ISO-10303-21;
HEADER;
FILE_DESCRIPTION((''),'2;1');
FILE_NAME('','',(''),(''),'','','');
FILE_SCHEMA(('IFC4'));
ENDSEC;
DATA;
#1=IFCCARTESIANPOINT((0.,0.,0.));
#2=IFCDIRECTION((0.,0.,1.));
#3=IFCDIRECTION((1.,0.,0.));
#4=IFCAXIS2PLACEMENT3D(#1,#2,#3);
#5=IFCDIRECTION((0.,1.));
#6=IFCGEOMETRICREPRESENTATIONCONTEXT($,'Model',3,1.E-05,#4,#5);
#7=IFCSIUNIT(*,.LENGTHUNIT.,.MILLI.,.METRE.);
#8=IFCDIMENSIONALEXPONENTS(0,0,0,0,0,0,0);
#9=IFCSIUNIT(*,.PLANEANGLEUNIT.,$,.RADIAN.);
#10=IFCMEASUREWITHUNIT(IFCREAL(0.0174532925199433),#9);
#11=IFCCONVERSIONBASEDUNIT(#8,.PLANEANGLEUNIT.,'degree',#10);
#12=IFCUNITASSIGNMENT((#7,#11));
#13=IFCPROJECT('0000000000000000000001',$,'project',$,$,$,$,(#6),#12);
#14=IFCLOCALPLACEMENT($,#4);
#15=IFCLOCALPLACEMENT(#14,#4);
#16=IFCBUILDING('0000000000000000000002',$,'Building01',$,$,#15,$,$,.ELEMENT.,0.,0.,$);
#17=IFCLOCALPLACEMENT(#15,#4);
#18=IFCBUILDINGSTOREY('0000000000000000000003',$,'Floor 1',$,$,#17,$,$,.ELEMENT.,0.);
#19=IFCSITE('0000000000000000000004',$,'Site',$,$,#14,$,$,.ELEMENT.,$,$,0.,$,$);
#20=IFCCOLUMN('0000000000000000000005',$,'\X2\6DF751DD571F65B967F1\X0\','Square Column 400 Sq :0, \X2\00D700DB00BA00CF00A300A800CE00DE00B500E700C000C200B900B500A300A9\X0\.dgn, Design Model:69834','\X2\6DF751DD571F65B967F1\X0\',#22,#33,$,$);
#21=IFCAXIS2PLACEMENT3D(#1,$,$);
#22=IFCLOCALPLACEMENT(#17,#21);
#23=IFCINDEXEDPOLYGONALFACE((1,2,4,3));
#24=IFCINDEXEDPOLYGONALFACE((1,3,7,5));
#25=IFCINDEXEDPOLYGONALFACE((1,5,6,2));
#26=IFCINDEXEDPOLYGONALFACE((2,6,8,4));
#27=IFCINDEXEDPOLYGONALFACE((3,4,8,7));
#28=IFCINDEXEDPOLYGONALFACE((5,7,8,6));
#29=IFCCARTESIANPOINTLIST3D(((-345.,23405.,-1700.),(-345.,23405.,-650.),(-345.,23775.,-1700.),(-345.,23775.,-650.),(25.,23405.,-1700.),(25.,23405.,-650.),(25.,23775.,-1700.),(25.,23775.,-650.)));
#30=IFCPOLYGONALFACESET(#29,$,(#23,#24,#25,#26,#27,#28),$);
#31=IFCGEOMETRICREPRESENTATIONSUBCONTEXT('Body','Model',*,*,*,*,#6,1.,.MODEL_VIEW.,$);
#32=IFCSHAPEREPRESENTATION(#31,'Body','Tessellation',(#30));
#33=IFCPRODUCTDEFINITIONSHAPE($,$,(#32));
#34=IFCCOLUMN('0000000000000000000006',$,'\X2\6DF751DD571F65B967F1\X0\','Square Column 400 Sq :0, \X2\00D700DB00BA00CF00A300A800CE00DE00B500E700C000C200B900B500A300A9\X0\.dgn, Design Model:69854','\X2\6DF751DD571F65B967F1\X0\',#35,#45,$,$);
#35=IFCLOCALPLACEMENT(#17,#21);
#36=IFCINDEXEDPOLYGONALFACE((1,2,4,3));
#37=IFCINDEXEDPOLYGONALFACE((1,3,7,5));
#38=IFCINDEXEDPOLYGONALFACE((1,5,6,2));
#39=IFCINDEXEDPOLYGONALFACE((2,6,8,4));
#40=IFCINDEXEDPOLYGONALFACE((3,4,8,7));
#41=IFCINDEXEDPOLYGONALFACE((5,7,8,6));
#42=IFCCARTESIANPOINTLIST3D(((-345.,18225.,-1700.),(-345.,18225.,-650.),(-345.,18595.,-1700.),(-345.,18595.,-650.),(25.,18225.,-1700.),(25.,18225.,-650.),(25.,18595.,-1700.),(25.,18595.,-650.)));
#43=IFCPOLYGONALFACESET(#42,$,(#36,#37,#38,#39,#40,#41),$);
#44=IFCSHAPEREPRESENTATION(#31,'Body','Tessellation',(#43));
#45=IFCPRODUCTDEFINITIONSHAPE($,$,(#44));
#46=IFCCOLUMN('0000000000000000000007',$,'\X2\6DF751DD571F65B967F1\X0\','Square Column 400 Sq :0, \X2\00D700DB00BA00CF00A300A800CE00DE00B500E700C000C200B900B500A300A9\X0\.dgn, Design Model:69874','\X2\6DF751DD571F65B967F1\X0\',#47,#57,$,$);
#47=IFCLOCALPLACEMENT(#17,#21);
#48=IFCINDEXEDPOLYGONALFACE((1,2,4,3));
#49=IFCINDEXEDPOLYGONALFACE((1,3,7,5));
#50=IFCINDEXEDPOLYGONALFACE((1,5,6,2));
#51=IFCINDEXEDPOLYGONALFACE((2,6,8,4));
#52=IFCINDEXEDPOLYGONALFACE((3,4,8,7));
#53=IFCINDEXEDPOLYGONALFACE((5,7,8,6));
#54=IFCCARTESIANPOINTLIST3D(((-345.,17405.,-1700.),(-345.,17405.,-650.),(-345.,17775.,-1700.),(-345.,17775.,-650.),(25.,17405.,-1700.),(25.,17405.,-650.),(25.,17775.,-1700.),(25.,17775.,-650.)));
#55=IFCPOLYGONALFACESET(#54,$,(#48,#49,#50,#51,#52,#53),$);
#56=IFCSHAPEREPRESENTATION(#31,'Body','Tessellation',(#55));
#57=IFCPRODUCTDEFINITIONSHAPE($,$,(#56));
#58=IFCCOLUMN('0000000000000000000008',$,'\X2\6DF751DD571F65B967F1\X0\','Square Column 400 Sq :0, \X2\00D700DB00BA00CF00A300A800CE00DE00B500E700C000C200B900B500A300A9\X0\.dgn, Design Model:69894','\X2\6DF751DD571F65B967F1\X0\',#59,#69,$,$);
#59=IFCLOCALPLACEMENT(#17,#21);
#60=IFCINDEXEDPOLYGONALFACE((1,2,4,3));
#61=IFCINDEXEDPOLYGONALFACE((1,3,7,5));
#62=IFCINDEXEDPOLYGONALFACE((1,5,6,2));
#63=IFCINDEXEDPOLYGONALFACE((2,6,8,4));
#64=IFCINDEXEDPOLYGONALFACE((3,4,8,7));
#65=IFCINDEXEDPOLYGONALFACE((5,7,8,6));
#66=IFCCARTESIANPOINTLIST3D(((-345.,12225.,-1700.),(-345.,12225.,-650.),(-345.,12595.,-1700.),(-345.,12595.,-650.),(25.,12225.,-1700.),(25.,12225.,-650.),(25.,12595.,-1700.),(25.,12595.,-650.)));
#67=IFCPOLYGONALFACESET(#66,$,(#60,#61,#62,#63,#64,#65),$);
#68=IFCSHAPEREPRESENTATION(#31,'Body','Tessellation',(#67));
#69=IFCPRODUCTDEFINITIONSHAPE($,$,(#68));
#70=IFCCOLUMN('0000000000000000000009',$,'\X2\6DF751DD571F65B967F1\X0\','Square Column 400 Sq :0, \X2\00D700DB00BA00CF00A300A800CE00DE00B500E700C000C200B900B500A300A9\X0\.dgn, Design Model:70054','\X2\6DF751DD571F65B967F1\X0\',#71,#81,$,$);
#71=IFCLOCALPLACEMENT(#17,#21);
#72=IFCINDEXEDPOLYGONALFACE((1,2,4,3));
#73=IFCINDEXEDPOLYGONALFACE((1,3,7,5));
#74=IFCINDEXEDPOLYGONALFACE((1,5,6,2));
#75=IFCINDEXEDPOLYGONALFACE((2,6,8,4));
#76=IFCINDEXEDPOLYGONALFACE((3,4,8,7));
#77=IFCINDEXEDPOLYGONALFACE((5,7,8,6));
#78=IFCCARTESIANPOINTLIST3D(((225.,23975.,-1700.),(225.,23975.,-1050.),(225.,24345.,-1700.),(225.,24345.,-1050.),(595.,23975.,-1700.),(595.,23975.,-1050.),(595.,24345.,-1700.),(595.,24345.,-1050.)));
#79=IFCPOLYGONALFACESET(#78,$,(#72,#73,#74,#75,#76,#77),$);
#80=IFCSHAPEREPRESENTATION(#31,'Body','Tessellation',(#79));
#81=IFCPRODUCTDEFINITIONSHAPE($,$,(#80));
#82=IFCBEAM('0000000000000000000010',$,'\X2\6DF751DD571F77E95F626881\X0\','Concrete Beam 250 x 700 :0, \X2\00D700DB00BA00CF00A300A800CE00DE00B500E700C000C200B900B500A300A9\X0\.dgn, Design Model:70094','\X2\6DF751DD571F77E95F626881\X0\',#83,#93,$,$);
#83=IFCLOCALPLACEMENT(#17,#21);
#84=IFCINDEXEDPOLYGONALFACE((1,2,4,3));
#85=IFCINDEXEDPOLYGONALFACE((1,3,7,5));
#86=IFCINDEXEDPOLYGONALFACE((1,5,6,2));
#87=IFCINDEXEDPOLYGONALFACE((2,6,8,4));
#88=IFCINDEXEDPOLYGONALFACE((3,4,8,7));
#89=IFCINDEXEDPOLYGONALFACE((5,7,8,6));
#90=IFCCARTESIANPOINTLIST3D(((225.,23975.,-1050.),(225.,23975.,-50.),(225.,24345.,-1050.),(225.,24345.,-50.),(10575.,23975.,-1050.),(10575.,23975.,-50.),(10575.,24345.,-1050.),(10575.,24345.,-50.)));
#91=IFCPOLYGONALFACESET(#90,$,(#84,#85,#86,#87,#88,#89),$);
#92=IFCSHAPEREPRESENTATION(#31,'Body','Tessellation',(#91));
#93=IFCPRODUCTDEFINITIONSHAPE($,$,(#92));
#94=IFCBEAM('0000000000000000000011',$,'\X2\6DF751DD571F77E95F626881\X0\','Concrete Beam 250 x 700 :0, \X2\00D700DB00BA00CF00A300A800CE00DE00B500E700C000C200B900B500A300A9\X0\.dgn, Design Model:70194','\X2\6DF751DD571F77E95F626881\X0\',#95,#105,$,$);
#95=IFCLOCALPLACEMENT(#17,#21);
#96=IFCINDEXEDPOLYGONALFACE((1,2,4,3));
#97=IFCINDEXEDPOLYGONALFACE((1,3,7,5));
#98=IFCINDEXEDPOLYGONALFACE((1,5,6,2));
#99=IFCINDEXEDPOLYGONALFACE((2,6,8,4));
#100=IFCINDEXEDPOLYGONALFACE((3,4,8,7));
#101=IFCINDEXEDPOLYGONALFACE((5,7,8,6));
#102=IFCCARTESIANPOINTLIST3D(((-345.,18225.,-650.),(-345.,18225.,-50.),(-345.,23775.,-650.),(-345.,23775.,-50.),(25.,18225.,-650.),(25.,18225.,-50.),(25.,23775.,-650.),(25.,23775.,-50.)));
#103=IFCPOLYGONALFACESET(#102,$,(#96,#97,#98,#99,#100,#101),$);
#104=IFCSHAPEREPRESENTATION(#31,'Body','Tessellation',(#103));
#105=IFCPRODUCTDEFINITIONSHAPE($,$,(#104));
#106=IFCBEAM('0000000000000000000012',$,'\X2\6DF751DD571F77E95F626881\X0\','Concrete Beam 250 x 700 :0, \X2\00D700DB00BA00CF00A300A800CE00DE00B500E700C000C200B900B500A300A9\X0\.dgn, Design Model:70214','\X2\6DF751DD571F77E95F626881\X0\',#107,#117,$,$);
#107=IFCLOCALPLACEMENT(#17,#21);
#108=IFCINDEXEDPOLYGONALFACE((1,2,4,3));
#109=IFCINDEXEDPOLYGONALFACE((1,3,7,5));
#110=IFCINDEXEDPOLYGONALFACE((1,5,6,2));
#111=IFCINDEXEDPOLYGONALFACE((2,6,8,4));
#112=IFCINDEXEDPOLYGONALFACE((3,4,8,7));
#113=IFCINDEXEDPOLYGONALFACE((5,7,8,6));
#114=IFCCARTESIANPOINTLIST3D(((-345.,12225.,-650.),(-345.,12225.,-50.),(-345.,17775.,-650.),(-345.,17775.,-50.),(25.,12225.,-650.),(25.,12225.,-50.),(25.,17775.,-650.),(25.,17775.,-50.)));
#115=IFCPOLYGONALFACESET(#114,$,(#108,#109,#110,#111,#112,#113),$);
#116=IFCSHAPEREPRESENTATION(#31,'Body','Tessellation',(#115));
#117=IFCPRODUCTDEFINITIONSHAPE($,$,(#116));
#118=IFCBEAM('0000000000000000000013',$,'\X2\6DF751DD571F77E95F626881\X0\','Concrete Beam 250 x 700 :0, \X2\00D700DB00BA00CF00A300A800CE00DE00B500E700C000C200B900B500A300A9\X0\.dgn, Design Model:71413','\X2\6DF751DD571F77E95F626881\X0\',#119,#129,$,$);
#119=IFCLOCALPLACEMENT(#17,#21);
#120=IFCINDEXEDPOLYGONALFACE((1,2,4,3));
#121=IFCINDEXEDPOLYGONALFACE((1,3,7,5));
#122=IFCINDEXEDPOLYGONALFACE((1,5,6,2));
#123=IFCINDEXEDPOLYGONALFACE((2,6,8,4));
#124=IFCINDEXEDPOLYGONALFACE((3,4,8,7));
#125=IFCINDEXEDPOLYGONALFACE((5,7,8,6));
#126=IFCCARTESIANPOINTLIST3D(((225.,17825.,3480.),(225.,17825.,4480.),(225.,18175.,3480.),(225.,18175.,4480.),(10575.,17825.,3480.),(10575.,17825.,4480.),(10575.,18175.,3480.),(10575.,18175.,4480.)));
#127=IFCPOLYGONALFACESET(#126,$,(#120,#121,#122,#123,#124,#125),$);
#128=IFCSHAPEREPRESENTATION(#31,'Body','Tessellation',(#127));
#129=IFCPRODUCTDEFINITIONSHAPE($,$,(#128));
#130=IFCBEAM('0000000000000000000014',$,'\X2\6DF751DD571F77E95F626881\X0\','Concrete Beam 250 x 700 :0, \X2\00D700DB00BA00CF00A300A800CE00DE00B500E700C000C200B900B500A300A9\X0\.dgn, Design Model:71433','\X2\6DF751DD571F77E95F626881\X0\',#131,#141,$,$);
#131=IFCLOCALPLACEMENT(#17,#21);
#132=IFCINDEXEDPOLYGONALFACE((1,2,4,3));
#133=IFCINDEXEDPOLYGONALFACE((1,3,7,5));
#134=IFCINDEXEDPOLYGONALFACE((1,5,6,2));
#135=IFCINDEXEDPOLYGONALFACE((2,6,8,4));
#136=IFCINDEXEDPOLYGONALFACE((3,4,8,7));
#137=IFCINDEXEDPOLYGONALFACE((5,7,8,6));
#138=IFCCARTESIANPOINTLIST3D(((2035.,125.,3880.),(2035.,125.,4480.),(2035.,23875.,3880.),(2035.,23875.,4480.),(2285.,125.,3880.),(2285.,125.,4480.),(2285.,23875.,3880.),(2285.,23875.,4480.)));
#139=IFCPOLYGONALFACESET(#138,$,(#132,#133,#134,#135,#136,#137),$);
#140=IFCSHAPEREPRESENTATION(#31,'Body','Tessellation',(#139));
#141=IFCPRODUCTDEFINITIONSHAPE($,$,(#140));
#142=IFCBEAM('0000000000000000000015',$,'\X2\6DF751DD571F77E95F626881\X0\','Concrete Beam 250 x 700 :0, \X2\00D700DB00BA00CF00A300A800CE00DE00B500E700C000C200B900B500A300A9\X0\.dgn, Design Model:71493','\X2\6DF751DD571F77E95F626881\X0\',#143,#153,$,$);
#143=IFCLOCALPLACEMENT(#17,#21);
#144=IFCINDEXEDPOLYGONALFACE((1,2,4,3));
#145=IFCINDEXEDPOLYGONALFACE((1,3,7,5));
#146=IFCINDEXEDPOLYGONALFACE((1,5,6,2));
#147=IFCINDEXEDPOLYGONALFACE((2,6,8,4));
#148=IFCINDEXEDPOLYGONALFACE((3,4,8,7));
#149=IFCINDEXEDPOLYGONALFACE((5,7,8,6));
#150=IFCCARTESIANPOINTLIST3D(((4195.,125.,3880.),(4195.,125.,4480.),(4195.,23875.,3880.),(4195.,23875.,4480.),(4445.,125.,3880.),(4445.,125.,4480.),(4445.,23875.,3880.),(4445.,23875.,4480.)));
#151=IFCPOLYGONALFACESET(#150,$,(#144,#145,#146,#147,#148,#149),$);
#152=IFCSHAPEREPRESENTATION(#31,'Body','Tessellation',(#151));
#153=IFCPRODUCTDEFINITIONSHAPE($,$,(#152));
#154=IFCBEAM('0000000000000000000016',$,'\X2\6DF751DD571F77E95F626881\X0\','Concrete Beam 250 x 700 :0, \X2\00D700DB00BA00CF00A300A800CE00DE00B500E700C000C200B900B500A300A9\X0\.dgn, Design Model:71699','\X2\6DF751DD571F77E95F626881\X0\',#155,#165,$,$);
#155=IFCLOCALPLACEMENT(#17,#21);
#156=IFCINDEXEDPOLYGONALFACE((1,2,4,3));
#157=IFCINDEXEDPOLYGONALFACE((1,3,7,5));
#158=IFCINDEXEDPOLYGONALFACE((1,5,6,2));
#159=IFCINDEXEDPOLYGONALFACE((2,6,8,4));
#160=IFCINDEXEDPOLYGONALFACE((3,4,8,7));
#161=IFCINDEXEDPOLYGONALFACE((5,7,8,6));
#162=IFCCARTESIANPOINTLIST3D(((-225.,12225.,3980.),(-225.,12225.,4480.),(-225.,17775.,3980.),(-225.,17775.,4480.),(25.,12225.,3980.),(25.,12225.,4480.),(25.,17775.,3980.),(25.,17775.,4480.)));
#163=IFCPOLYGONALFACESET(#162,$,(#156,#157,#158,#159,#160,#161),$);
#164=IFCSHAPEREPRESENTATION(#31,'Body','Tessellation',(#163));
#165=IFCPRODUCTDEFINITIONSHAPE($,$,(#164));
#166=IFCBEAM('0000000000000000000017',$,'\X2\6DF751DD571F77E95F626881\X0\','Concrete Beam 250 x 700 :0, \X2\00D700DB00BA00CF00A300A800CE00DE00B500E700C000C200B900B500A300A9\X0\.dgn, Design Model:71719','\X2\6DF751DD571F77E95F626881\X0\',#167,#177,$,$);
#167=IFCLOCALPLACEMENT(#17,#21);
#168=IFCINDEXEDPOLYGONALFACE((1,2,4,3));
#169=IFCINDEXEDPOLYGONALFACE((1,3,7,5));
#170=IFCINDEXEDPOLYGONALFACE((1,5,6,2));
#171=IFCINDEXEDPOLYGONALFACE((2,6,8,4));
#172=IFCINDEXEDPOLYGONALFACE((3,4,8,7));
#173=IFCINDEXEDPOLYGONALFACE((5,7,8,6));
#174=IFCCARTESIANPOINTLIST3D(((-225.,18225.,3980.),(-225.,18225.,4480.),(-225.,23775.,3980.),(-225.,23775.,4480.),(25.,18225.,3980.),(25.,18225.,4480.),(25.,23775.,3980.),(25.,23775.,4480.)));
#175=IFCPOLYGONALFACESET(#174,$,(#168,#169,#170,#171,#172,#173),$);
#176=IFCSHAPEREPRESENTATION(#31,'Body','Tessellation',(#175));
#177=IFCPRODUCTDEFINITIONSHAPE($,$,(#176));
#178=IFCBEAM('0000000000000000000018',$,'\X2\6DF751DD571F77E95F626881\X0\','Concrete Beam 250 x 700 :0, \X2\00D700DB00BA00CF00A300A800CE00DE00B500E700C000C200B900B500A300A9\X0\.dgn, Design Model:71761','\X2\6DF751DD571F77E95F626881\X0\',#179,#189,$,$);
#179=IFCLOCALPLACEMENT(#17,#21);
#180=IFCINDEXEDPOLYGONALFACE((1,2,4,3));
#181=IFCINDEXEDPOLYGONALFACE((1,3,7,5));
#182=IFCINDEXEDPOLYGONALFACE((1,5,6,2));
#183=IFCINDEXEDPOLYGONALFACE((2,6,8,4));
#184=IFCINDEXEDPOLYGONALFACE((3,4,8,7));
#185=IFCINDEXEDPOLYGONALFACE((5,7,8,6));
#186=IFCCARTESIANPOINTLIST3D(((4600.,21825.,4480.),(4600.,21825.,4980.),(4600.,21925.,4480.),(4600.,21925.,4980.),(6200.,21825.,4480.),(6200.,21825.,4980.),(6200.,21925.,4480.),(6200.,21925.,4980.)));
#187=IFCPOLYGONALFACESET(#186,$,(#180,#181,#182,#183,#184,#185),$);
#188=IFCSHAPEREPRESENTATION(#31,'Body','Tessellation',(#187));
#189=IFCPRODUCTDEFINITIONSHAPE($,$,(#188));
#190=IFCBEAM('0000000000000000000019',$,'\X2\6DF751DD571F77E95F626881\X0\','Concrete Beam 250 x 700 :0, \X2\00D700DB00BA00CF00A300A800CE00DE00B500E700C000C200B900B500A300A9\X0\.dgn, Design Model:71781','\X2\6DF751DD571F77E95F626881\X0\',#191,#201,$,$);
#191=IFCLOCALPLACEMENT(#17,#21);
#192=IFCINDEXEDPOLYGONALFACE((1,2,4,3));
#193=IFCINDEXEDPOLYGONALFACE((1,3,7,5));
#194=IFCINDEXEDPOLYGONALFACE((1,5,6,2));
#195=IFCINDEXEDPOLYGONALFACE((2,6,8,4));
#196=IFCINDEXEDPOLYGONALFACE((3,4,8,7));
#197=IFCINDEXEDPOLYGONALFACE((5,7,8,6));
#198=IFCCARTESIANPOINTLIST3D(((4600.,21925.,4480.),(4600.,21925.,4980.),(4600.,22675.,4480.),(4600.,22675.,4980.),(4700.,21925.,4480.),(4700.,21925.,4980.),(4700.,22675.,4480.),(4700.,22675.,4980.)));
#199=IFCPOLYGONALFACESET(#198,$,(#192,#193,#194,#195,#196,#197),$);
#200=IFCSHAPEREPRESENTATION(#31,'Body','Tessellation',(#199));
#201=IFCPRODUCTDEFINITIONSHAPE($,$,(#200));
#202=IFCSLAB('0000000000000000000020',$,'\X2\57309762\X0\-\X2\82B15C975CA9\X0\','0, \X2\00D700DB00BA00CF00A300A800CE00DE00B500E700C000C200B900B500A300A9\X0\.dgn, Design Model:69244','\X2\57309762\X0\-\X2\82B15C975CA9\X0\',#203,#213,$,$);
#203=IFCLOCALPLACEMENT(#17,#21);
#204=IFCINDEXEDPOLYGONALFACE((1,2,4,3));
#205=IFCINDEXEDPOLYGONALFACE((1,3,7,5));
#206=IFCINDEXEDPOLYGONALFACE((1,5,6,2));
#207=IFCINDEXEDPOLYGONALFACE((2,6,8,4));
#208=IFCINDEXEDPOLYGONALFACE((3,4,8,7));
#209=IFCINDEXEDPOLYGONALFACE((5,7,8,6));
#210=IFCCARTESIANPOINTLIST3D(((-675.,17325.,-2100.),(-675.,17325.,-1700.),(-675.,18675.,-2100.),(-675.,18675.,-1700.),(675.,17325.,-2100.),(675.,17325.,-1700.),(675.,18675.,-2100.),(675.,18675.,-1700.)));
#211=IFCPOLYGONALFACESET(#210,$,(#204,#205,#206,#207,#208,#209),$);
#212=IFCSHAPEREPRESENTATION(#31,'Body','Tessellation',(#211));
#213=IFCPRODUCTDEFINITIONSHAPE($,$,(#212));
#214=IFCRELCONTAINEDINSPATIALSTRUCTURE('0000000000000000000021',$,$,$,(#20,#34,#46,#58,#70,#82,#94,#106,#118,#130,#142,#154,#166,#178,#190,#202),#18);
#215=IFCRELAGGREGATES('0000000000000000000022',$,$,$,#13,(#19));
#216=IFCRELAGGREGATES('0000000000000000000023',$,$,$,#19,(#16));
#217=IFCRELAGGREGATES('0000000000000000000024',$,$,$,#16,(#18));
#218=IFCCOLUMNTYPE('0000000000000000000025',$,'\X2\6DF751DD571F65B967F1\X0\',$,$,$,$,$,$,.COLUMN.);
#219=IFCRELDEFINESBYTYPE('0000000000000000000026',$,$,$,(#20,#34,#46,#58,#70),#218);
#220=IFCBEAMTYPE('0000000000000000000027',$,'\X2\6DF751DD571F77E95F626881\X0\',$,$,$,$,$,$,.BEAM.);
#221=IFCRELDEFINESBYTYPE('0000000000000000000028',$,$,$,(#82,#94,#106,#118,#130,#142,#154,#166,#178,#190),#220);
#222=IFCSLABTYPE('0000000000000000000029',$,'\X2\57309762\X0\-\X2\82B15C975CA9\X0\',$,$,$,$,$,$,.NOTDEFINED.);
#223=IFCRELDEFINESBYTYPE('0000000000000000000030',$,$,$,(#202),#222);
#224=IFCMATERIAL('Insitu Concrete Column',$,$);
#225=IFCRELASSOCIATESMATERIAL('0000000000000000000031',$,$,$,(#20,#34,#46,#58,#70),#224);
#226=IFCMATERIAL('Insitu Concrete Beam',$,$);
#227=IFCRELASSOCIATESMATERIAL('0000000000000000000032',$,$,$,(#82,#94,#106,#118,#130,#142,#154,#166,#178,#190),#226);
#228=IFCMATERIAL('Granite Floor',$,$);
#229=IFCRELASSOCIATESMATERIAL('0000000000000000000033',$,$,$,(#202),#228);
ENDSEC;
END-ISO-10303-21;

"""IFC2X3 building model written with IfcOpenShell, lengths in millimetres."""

from ifc_helpers import new_model, entity, si_unit, converted_unit, direction, frame, frame_2d, origin_with_axes, place, context, subcontext, project, spatial, rectangle, extrude, material, type_object, element, save


model = new_model("IFC2X3")

# Units and contexts
model_context = context("Model", 3, precision=1e-05, world=origin_with_axes(), true_north=direction((0.0, 1.0)))
body_context = subcontext(model_context, "Body", "Model", "MODEL_VIEW", scale=1.0)
ifc_project = project(units=[si_unit("LENGTHUNIT", "METRE", prefix="MILLI"), converted_unit("PLANEANGLEUNIT", "degree", entity("IfcReal", 0.0174532925199433), si_unit("PLANEANGLEUNIT", "RADIAN"), dimensions=[0, 0, 0, 0, 0, 0, 0])], contexts=[model_context])

# Site, building, storey
site_placement = place(None, origin_with_axes())
site = spatial("IfcSite", under=ifc_project, at=site_placement, Name="Site", CompositionType="ELEMENT", RefElevation=0.0)
building_placement = place(site_placement, origin_with_axes())
building = spatial("IfcBuilding", under=site, at=building_placement, Name="Building01", CompositionType="ELEMENT", ElevationOfRefHeight=0.0, ElevationOfTerrain=0.0)
storey_placement = place(building_placement, origin_with_axes())
storey = spatial("IfcBuildingStorey", under=building, at=storey_placement, Name="Floor 1", CompositionType="ELEMENT", Elevation=0.0)

# Columns
ifc_material_1 = material(Name="Insitu Concrete Column")
column_type = type_object("IfcColumnType", Name="混凝土方柱", PredefinedType="COLUMN")
for number, where, z_axis, x_axis, name, description in (
    (1, (25.0, 23405.0, -1700.0), (0.0, 0.0, 1.0), (0.0, 1.0, 0.0), "混凝土方柱", "Square Column 400 Sq :0, ×ÛºÏ£¨ÎÞµçÀÂ¹µ£©.dgn, Design Model:69834"),
    (2, (25.0, 18595.0, -1700.0), (0.0, 0.0, 1.0), (-1.0, 0.0, 0.0), "混凝土方柱", "Square Column 400 Sq :0, ×ÛºÏ£¨ÎÞµçÀÂ¹µ£©.dgn, Design Model:69854"),
    (3, (25.0, 17405.0, -1700.0), (0.0, 0.0, 1.0), (0.0, 1.0, 0.0), "混凝土方柱", "Square Column 400 Sq :0, ×ÛºÏ£¨ÎÞµçÀÂ¹µ£©.dgn, Design Model:69874"),
    (4, (25.0, 12595.0, -1700.0), (0.0, 0.0, 1.0), (-1.0, 0.0, 0.0), "混凝土方柱", "Square Column 400 Sq :0, ×ÛºÏ£¨ÎÞµçÀÂ¹µ£©.dgn, Design Model:69894"),
):
    element("IfcColumn", number, at=place(storey_placement, frame(where, z_axis=z_axis, x_axis=x_axis)), inside=storey, type_object=column_type, material=ifc_material_1, Name=name, Description=description, ObjectType="混凝土方柱", context=body_context, shape_type="SweptSolid", body=[
        extrude(rectangle(XDim=370.0, YDim=370.0, at=frame_2d((185.0, 185.0), x_axis=(0.0, 1.0))), origin_with_axes(), (0.0, 0.0, 1.0), 1050.0),
    ])
column_placement = place(storey_placement, frame((225.0, 23975.0, -1700.0), z_axis=(0.0, 0.0, 1.0), x_axis=(1.0, 0.0, 0.0)))
element("IfcColumn", 5, at=column_placement, inside=storey, type_object=column_type, material=ifc_material_1, Name="混凝土方柱", Description="Square Column 400 Sq :0, ×ÛºÏ£¨ÎÞµçÀÂ¹µ£©.dgn, Design Model:70054", ObjectType="混凝土方柱", context=body_context, shape_type="SweptSolid", body=[
    extrude(rectangle(XDim=370.0, YDim=370.0, at=frame_2d((185.0, 185.0), x_axis=(0.0, 1.0))), origin_with_axes(), (0.0, 0.0, 1.0), 650.0),
])

# Beams
ifc_material_2 = material(Name="Insitu Concrete Beam")
beam_type = type_object("IfcBeamType", Name="混凝土矩形梁", PredefinedType="BEAM")
beam_1_placement = place(storey_placement, frame((225.0, 24345.0, -1050.0), z_axis=(1.0, 0.0, 0.0), x_axis=(0.0, 0.0, 1.0)))
element("IfcBeam", 6, at=beam_1_placement, inside=storey, type_object=beam_type, material=ifc_material_2, Name="混凝土矩形梁", Description="Concrete Beam 250 x 700 :0, ×ÛºÏ£¨ÎÞµçÀÂ¹µ£©.dgn, Design Model:70094", ObjectType="混凝土矩形梁", context=body_context, shape_type="SweptSolid", body=[
    extrude(rectangle(XDim=370.0, YDim=1000.0, at=frame_2d((500.0, 185.0), x_axis=(0.0, 1.0))), origin_with_axes(), (0.0, 0.0, 1.0), 10350.0),
])
for number, where, z_axis, x_axis, name, description in (
    (7, (-345.0, 18225.0, -650.0), (0.0, 1.0, 0.0), (0.0, 0.0, 1.0), "混凝土矩形梁", "Concrete Beam 250 x 700 :0, ×ÛºÏ£¨ÎÞµçÀÂ¹µ£©.dgn, Design Model:70194"),
    (8, (-345.0, 12225.0, -650.0), (0.0, 1.0, 0.0), (0.0, 0.0, 1.0), "混凝土矩形梁", "Concrete Beam 250 x 700 :0, ×ÛºÏ£¨ÎÞµçÀÂ¹µ£©.dgn, Design Model:70214"),
):
    element("IfcBeam", number, at=place(storey_placement, frame(where, z_axis=z_axis, x_axis=x_axis)), inside=storey, type_object=beam_type, material=ifc_material_2, Name=name, Description=description, ObjectType="混凝土矩形梁", context=body_context, shape_type="SweptSolid", body=[
        extrude(rectangle(XDim=370.0, YDim=600.0, at=frame_2d((300.0, 185.0), x_axis=(0.0, 1.0))), origin_with_axes(), (0.0, 0.0, 1.0), 5550.0),
    ])
beam_2_placement = place(storey_placement, frame((225.0, 17825.0, 3480.0), z_axis=(1.0, 0.0, 0.0), x_axis=(0.0, 1.0, 0.0)))
element("IfcBeam", 9, at=beam_2_placement, inside=storey, type_object=beam_type, material=ifc_material_2, Name="混凝土矩形梁", Description="Concrete Beam 250 x 700 :0, ×ÛºÏ£¨ÎÞµçÀÂ¹µ£©.dgn, Design Model:71413", ObjectType="混凝土矩形梁", context=body_context, shape_type="SweptSolid", body=[
    extrude(rectangle(XDim=1000.0, YDim=350.0, at=frame_2d((175.0, 500.0), x_axis=(0.0, 1.0))), origin_with_axes(), (0.0, 0.0, 1.0), 10350.0),
])
for number, where, z_axis, x_axis, name, description in (
    (10, (2035.0, 23875.0, 3880.0), (0.0, -1.0, 0.0), (1.0, 0.0, 0.0), "混凝土矩形梁", "Concrete Beam 250 x 700 :0, ×ÛºÏ£¨ÎÞµçÀÂ¹µ£©.dgn, Design Model:71433"),
    (11, (4195.0, 23875.0, 3880.0), (0.0, -1.0, 0.0), (1.0, 0.0, 0.0), "混凝土矩形梁", "Concrete Beam 250 x 700 :0, ×ÛºÏ£¨ÎÞµçÀÂ¹µ£©.dgn, Design Model:71493"),
):
    element("IfcBeam", number, at=place(storey_placement, frame(where, z_axis=z_axis, x_axis=x_axis)), inside=storey, type_object=beam_type, material=ifc_material_2, Name=name, Description=description, ObjectType="混凝土矩形梁", context=body_context, shape_type="SweptSolid", body=[
        extrude(rectangle(XDim=600.0, YDim=250.0, at=frame_2d((125.0, 300.0), x_axis=(0.0, 1.0))), origin_with_axes(), (0.0, 0.0, 1.0), 23750.0),
    ])
for number, where, z_axis, x_axis, name, description in (
    (12, (-225.0, 17775.0, 3980.0), (0.0, -1.0, 0.0), (1.0, 0.0, 0.0), "混凝土矩形梁", "Concrete Beam 250 x 700 :0, ×ÛºÏ£¨ÎÞµçÀÂ¹µ£©.dgn, Design Model:71699"),
    (13, (-225.0, 23775.0, 3980.0), (0.0, -1.0, 0.0), (1.0, 0.0, 0.0), "混凝土矩形梁", "Concrete Beam 250 x 700 :0, ×ÛºÏ£¨ÎÞµçÀÂ¹µ£©.dgn, Design Model:71719"),
):
    element("IfcBeam", number, at=place(storey_placement, frame(where, z_axis=z_axis, x_axis=x_axis)), inside=storey, type_object=beam_type, material=ifc_material_2, Name=name, Description=description, ObjectType="混凝土矩形梁", context=body_context, shape_type="SweptSolid", body=[
        extrude(rectangle(XDim=500.0, YDim=250.0, at=frame_2d((125.0, 250.0), x_axis=(0.0, 1.0))), origin_with_axes(), (0.0, 0.0, 1.0), 5550.0),
    ])
beam_3_placement = place(storey_placement, frame((4600.0, 21825.0, 4480.0), z_axis=(1.0, 0.0, 0.0), x_axis=(0.0, 1.0, 0.0)))
element("IfcBeam", 14, at=beam_3_placement, inside=storey, type_object=beam_type, material=ifc_material_2, Name="混凝土矩形梁", Description="Concrete Beam 250 x 700 :0, ×ÛºÏ£¨ÎÞµçÀÂ¹µ£©.dgn, Design Model:71761", ObjectType="混凝土矩形梁", context=body_context, shape_type="SweptSolid", body=[
    extrude(rectangle(XDim=500.0, YDim=100.0, at=frame_2d((50.0, 250.0), x_axis=(0.0, 1.0))), origin_with_axes(), (0.0, 0.0, 1.0), 1600.0),
])
beam_4_placement = place(storey_placement, frame((4600.0, 22675.0, 4480.0), z_axis=(0.0, -1.0, 0.0), x_axis=(1.0, 0.0, 0.0)))
element("IfcBeam", 15, at=beam_4_placement, inside=storey, type_object=beam_type, material=ifc_material_2, Name="混凝土矩形梁", Description="Concrete Beam 250 x 700 :0, ×ÛºÏ£¨ÎÞµçÀÂ¹µ£©.dgn, Design Model:71781", ObjectType="混凝土矩形梁", context=body_context, shape_type="SweptSolid", body=[
    extrude(rectangle(XDim=500.0, YDim=100.0, at=frame_2d((50.0, 250.0), x_axis=(0.0, 1.0))), origin_with_axes(), (0.0, 0.0, 1.0), 750.0),
])

# Slab
ifc_material_3 = material(Name="Granite Floor")
slab_type_1 = type_object("IfcSlabType", Name="地面-花岗岩", PredefinedType="NOTDEFINED")
slab_1_placement = place(storey_placement, frame((-675.0, 17325.0, -2100.0), z_axis=(0.0, 0.0, 1.0), x_axis=(1.0, 0.0, 0.0)))
element("IfcSlab", 16, at=slab_1_placement, inside=storey, type_object=slab_type_1, material=ifc_material_3, Name="地面-花岗岩", Description="0, ×ÛºÏ£¨ÎÞµçÀÂ¹µ£©.dgn, Design Model:69244", ObjectType="地面-花岗岩", context=body_context, shape_type="SweptSolid", body=[
    extrude(rectangle(XDim=1350.0, YDim=1350.0, at=frame_2d((675.0, 675.0), x_axis=(1.0, 0.0))), origin_with_axes(), (0.0, 0.0, 1.0), 400.0),
])

save(model, "model.ifc")
